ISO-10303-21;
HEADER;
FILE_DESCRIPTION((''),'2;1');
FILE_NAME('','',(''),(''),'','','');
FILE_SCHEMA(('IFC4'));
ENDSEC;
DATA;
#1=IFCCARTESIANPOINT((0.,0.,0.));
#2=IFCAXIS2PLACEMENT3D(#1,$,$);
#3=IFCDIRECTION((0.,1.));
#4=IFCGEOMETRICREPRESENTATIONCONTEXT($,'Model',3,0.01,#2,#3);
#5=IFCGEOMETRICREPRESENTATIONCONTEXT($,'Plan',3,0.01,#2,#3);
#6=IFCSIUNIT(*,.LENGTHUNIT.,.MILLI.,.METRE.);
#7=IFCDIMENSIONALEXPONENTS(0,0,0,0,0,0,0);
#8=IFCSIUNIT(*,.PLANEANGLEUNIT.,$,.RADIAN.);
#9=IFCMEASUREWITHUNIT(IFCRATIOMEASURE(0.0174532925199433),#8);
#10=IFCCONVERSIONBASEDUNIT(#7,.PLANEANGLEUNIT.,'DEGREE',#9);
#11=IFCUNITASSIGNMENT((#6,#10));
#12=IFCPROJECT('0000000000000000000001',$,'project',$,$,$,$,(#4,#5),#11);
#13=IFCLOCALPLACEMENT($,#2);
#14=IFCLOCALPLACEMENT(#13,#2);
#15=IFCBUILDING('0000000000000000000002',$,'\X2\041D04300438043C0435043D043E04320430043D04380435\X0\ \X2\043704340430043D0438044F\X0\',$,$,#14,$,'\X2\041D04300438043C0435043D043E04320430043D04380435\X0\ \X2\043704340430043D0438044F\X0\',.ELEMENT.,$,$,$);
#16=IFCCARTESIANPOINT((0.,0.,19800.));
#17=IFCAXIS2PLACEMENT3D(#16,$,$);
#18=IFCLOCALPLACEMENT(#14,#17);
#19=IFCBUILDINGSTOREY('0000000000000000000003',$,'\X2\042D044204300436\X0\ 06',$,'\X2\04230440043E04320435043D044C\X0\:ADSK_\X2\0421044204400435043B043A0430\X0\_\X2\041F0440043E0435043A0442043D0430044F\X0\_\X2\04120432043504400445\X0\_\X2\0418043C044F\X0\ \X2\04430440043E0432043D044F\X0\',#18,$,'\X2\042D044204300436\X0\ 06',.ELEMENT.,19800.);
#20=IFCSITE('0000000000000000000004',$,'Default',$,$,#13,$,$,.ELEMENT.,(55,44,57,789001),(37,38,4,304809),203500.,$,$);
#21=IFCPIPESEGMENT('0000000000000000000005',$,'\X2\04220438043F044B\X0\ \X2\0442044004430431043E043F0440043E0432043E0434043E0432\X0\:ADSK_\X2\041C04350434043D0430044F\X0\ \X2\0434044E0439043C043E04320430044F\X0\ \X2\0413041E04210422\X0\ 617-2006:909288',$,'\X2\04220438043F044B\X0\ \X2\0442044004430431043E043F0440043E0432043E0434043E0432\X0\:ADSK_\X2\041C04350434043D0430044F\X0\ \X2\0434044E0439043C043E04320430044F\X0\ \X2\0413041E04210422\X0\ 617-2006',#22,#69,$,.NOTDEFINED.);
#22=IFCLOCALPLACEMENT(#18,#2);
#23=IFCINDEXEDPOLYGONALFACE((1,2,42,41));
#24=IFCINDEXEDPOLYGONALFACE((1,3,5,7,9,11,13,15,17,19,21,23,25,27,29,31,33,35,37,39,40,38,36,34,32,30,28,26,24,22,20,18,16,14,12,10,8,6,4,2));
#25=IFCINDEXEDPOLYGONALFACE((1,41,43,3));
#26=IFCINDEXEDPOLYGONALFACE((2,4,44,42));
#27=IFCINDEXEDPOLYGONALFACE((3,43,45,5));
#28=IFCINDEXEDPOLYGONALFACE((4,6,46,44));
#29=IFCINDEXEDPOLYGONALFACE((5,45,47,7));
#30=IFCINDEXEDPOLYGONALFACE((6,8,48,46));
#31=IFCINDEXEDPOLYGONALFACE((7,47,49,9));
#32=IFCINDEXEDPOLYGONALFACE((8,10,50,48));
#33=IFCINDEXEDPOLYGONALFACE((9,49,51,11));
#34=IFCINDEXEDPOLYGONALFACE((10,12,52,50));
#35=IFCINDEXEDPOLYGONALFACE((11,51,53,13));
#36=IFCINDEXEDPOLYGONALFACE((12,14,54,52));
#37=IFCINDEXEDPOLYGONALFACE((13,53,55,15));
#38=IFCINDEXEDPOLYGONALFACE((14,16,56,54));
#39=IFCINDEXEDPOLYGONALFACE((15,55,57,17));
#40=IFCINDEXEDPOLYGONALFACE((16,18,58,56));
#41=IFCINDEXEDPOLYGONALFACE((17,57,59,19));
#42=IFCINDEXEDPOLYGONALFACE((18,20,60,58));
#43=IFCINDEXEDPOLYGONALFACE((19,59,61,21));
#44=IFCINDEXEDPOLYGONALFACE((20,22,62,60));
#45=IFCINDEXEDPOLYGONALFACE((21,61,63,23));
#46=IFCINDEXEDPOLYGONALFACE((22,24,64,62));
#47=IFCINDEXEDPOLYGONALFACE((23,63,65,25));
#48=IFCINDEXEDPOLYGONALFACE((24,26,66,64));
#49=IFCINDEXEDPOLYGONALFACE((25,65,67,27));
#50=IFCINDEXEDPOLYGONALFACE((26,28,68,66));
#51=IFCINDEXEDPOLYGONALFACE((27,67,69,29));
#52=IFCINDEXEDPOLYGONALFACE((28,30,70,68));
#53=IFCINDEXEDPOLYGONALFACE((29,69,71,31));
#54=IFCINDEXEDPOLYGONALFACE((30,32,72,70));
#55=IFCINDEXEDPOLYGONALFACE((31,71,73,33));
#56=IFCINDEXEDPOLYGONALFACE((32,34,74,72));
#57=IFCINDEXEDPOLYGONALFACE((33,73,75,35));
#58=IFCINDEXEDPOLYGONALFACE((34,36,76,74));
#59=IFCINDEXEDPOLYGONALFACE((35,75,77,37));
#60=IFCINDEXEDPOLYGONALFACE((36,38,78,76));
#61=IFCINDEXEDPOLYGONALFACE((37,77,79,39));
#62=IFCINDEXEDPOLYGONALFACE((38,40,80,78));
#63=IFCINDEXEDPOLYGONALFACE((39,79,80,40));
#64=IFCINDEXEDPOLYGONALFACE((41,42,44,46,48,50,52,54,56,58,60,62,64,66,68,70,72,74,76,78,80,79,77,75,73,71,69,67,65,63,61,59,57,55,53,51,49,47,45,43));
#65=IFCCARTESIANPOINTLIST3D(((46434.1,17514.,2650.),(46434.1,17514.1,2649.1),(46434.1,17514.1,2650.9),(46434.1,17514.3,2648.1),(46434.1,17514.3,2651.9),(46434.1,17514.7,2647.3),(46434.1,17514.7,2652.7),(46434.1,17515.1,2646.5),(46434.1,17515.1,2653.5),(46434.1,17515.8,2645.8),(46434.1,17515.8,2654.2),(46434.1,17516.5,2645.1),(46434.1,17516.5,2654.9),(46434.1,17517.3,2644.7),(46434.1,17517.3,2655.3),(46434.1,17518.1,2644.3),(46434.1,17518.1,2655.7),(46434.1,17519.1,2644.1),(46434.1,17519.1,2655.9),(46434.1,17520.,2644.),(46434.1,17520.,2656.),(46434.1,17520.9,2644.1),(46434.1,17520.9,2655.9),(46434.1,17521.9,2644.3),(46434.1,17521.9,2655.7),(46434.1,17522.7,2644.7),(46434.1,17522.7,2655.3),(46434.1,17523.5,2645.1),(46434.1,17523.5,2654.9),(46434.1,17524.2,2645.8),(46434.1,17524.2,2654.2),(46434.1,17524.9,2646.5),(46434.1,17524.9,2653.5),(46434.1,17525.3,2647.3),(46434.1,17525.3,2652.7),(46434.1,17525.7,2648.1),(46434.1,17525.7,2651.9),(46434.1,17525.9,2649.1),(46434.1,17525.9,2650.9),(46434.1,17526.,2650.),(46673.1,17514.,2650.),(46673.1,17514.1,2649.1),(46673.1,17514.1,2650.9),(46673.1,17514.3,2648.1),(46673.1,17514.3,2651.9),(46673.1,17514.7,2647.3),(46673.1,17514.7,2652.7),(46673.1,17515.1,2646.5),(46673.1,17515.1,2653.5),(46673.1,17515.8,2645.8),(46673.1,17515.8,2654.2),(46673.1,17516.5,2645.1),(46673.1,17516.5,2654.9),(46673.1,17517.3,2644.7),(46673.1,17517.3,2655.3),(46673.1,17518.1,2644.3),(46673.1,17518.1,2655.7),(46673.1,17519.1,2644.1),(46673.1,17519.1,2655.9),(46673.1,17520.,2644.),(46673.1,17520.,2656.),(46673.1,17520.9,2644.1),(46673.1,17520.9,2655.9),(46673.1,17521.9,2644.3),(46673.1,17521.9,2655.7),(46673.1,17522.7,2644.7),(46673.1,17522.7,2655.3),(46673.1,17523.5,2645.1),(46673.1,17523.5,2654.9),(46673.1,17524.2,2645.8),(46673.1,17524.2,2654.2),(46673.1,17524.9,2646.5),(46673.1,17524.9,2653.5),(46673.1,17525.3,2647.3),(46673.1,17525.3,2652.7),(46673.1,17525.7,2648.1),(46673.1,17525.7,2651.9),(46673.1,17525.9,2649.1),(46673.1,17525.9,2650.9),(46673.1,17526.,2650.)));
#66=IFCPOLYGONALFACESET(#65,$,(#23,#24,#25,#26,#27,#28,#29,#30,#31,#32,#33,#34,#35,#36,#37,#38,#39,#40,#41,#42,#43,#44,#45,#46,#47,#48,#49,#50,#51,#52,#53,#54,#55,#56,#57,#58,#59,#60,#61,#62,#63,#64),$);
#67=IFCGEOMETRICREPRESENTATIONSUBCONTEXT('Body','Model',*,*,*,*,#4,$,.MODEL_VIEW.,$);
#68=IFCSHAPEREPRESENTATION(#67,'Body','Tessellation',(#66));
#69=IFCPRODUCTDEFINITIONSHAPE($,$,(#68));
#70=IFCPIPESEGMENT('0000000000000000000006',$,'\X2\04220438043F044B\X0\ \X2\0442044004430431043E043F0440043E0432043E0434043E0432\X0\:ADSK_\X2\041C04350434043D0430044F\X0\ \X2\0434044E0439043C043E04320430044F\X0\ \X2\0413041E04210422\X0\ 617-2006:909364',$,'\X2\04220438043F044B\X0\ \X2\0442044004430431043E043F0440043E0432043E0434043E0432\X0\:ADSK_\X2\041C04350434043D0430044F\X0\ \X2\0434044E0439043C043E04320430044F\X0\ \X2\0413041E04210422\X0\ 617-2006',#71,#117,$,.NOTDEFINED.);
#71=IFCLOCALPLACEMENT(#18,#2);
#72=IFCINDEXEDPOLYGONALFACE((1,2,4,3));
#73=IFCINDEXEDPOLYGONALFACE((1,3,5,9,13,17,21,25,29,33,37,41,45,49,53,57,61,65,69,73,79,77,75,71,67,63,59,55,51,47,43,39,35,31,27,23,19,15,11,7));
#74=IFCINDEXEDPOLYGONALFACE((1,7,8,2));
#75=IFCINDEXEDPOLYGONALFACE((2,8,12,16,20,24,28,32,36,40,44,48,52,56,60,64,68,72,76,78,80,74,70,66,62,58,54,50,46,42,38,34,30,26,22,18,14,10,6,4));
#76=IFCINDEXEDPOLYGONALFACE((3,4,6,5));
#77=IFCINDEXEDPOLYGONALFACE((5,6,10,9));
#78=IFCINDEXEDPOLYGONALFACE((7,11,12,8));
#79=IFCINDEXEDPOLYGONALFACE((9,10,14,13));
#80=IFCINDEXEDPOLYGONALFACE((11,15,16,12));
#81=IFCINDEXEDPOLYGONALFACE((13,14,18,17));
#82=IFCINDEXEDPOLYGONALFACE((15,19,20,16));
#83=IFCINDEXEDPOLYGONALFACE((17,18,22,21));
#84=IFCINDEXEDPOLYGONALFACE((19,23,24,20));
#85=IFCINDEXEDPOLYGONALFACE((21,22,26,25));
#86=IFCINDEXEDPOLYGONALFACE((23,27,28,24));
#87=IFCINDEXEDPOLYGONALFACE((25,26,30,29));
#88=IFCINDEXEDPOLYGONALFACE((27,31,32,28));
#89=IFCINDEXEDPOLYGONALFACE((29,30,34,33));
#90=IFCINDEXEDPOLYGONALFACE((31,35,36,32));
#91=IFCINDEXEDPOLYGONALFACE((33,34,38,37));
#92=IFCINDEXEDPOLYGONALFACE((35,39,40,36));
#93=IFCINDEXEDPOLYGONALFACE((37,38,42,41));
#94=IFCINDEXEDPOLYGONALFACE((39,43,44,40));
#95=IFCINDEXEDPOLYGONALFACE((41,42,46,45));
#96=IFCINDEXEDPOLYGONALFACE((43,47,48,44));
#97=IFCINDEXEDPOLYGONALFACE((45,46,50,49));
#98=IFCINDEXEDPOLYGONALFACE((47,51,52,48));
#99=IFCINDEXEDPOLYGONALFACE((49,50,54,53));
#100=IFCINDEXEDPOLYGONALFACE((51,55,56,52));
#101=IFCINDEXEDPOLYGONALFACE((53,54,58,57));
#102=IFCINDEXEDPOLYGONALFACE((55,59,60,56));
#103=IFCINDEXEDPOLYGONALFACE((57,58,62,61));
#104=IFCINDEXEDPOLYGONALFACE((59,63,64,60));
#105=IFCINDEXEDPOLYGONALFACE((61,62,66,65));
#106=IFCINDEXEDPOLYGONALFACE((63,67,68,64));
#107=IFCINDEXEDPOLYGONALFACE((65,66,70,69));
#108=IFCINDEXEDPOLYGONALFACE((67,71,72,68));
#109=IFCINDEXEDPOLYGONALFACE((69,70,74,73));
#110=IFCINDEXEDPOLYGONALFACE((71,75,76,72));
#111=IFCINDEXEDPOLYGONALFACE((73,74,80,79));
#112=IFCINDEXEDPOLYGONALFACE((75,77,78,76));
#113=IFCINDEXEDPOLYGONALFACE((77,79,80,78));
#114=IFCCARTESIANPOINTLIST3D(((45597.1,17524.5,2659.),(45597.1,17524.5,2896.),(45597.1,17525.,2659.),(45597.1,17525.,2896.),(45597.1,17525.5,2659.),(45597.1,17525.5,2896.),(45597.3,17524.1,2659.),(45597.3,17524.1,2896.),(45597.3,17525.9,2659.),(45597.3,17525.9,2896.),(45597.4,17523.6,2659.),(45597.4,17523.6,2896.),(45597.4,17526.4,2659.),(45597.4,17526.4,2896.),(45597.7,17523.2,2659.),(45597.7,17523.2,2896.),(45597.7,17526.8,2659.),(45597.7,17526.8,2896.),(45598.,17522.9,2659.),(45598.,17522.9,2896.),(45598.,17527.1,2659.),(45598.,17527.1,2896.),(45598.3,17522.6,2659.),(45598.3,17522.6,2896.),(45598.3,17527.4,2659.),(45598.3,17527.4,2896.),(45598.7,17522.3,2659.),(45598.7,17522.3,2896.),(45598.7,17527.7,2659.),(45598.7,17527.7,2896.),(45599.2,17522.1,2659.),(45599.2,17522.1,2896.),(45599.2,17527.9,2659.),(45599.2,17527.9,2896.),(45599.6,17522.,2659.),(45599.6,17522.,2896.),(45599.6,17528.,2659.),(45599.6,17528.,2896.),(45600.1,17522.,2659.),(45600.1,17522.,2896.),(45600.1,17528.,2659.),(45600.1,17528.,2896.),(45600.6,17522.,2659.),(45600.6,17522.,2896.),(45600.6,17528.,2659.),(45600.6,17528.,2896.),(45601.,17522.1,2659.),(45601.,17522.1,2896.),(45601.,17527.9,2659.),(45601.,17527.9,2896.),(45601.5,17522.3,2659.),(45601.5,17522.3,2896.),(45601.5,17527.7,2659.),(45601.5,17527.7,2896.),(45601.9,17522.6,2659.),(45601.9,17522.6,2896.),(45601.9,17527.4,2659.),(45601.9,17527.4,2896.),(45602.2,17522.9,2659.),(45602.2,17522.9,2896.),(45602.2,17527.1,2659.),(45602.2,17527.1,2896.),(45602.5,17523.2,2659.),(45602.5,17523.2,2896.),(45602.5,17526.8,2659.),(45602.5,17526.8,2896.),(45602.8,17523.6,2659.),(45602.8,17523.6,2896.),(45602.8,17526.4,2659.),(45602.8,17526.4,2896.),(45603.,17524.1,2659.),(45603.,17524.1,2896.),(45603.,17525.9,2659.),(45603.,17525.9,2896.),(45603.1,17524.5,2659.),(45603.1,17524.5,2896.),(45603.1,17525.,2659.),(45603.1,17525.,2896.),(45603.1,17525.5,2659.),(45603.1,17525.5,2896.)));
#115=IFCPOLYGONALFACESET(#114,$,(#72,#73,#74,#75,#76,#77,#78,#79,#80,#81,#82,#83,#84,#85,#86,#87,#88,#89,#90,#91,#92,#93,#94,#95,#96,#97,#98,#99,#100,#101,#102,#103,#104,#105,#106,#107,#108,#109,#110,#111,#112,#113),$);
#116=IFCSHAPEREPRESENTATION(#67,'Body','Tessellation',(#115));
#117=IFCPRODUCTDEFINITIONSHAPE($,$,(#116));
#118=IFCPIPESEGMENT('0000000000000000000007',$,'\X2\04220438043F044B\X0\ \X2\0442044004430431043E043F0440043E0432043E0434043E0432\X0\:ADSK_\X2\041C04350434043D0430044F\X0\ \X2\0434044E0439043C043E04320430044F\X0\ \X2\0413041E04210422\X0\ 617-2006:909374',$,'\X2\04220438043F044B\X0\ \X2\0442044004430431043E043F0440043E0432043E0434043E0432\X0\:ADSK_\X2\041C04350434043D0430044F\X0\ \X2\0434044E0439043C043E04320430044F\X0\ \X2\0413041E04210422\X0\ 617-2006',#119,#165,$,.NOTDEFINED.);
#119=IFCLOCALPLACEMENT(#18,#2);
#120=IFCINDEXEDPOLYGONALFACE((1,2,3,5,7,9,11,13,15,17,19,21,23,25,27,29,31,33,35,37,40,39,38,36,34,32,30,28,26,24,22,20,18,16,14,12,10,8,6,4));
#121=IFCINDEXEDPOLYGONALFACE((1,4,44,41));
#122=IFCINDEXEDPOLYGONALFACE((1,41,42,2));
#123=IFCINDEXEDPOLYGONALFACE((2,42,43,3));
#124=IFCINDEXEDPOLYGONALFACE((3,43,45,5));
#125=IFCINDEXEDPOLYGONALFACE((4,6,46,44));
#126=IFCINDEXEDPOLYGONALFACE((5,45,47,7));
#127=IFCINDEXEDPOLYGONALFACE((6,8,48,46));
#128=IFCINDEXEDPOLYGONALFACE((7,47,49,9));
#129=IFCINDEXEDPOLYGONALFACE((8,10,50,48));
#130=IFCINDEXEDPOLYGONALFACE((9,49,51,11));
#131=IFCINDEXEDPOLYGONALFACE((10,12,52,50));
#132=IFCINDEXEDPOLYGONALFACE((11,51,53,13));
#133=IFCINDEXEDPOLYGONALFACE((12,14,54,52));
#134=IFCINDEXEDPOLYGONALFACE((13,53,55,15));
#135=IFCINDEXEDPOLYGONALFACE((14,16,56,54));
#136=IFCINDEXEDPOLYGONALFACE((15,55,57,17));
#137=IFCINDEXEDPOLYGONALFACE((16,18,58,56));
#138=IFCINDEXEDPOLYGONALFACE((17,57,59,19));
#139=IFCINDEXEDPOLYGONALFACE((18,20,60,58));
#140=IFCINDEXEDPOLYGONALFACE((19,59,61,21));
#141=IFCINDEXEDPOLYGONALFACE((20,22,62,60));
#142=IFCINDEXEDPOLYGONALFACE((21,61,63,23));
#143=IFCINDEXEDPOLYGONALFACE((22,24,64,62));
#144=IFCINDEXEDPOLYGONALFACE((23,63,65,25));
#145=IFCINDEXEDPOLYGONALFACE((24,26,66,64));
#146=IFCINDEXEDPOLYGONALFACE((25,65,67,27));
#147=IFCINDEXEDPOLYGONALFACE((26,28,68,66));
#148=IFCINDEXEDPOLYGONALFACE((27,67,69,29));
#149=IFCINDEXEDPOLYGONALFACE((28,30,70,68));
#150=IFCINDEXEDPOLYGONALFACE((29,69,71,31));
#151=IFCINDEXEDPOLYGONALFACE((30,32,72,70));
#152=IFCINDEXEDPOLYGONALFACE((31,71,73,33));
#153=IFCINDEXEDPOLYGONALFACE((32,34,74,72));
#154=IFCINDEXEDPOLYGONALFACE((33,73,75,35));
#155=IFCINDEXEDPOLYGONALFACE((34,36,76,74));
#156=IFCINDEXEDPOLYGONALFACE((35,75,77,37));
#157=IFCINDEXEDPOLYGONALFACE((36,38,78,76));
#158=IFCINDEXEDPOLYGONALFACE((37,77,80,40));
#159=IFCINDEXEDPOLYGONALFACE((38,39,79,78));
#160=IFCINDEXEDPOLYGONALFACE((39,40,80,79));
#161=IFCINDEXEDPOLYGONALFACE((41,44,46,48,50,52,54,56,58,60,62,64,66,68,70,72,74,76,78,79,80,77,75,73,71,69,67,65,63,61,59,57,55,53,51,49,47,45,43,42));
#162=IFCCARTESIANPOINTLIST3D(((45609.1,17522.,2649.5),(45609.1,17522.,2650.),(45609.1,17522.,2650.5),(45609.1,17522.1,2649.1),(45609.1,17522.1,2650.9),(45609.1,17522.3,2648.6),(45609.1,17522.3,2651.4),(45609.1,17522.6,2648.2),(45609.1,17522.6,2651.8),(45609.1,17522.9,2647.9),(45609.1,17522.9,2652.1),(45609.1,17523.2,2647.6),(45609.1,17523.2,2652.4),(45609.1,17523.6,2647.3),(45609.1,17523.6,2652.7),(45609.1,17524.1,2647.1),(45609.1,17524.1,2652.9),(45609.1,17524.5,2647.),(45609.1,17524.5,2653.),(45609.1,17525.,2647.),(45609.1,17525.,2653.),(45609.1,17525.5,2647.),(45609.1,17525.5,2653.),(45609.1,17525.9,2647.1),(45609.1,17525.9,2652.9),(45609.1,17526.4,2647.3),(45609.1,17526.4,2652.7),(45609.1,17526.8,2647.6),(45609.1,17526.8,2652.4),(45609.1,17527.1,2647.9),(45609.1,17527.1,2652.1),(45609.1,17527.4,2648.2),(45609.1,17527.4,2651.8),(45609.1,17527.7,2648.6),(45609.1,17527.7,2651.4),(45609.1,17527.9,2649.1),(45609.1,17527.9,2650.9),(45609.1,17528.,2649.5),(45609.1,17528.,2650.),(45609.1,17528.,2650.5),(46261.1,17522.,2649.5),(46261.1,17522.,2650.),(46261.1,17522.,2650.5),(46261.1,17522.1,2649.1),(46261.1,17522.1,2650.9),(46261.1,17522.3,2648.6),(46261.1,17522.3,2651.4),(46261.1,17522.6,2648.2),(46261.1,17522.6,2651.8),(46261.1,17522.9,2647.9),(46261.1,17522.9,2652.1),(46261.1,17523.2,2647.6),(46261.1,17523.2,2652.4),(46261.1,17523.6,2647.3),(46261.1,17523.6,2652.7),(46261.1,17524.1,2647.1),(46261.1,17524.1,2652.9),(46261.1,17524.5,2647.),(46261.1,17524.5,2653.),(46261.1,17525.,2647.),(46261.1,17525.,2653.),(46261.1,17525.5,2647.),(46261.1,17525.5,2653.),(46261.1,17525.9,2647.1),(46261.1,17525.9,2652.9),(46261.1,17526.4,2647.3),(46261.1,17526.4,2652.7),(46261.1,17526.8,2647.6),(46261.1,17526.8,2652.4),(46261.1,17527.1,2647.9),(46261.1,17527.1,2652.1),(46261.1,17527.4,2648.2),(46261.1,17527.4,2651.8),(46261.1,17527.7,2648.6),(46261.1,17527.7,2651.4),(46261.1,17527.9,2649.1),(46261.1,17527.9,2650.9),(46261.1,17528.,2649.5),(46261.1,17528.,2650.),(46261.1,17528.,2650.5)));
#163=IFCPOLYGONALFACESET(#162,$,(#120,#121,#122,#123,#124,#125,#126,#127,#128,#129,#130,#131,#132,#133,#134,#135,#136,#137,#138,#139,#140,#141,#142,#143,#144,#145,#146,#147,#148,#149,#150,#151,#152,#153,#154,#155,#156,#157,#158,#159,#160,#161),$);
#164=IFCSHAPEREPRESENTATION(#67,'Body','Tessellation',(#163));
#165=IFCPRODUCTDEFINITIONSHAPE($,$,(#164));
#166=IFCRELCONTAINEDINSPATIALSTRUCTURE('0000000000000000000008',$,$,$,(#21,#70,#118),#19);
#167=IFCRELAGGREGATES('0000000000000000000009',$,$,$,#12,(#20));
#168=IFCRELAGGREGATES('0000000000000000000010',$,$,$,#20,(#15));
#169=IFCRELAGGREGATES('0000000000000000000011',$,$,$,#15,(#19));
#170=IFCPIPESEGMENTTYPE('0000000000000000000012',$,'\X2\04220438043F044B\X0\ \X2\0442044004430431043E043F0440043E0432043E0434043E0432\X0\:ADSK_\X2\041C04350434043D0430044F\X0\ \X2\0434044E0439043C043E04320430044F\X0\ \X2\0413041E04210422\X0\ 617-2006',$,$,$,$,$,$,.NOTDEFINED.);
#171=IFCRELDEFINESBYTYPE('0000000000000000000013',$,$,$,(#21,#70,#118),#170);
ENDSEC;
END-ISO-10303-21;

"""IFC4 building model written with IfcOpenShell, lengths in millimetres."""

from ifc_helpers import new_model, entity, si_unit, converted_unit, direction, frame, origin, place, context, subcontext, project, spatial, indexed_curve, outline, extrude, type_object, element, save


model = new_model("IFC4")

# Units and contexts
model_context = context("Model", 3, precision=0.01, world=origin(), true_north=direction((0.0, 1.0)))
plan_context = context("Plan", 3, precision=0.01, world=origin(), true_north=direction((0.0, 1.0)))
body_context = subcontext(model_context, "Body", "Model", "MODEL_VIEW")
ifc_project = project(units=[si_unit("LENGTHUNIT", "METRE", prefix="MILLI"), converted_unit("PLANEANGLEUNIT", "DEGREE", entity("IfcRatioMeasure", 0.0174532925199433), si_unit("PLANEANGLEUNIT", "RADIAN"), dimensions=[0, 0, 0, 0, 0, 0, 0])], contexts=[model_context, plan_context])

# Site, building, storey
site_placement = place(None, origin())
site = spatial("IfcSite", under=ifc_project, at=site_placement, Name="Default", CompositionType="ELEMENT", RefLatitude=(55, 44, 57, 789001), RefLongitude=(37, 38, 4, 304809), RefElevation=203500.0)
building_placement = place(site_placement, origin())
building = spatial("IfcBuilding", under=site, at=building_placement, Name="Наименование здания", LongName="Наименование здания", CompositionType="ELEMENT")
storey_placement = place(building_placement, frame((0.0, 0.0, 19800.0)))
storey = spatial("IfcBuildingStorey", under=building, at=storey_placement, Name="Этаж 06", ObjectType="Уровень:ADSK_Стрелка_Проектная_Вверх_Имя уровня", LongName="Этаж 06", CompositionType="ELEMENT", Elevation=19800.0)

# Pipe segments
pipe_segment_type = type_object("IfcPipeSegmentType", Name="Типы трубопроводов:ADSK_Медная дюймовая ГОСТ 617-2006", PredefinedType="NOTDEFINED")
placement = place(storey_placement, origin())
element("IfcPipeSegment", 1, at=placement, inside=storey, type_object=pipe_segment_type, Name="Типы трубопроводов:ADSK_Медная дюймовая ГОСТ 617-2006:909288", ObjectType="Типы трубопроводов:ADSK_Медная дюймовая ГОСТ 617-2006", PredefinedType="NOTDEFINED", context=body_context, shape_type="SweptSolid", body=[
    extrude(outline(indexed_curve([(6.0, 0.0), (5.9, 0.9), (5.7, 1.9), (5.3, 2.7), (4.9, 3.5), (4.2, 4.2), (3.5, 4.9), (2.7, 5.3), (1.9, 5.7), (0.9, 5.9), (0.0, 6.0), (-0.9, 5.9), (-1.9, 5.7), (-2.7, 5.3), (-3.5, 4.9), (-4.2, 4.2), (-4.9, 3.5), (-5.3, 2.7), (-5.7, 1.9), (-5.9, 0.9), (-6.0, 0.0), (-5.9, -0.9), (-5.7, -1.9), (-5.3, -2.7), (-4.9, -3.5), (-4.2, -4.2), (-3.5, -4.9), (-2.7, -5.3), (-1.9, -5.7), (-0.9, -5.9), (0.0, -6.0), (0.9, -5.9), (1.9, -5.7), (2.7, -5.3), (3.5, -4.9), (4.2, -4.2), (4.9, -3.5), (5.3, -2.7), (5.7, -1.9), (5.9, -0.9), (6.0, 0.0)], self_intersect=False)), frame((46434.1, 17520.0, 2650.0), z_axis=(1.0, 0.0, 0.0), x_axis=(0.0, 1.0, 0.0)), (0.0, 0.0, 1.0), 239.0),
])
element("IfcPipeSegment", 2, at=placement, inside=storey, type_object=pipe_segment_type, Name="Типы трубопроводов:ADSK_Медная дюймовая ГОСТ 617-2006:909364", ObjectType="Типы трубопроводов:ADSK_Медная дюймовая ГОСТ 617-2006", PredefinedType="NOTDEFINED", context=body_context, shape_type="SweptSolid", body=[
    extrude(outline(indexed_curve([(3.0, 0.0), (3.0, 0.5), (2.9, 0.9), (2.7, 1.4), (2.4, 1.8), (2.1, 2.1), (1.8, 2.4), (1.4, 2.7), (0.9, 2.9), (0.5, 3.0), (0.0, 3.0), (-0.5, 3.0), (-0.9, 2.9), (-1.4, 2.7), (-1.8, 2.4), (-2.1, 2.1), (-2.4, 1.8), (-2.7, 1.4), (-2.9, 0.9), (-3.0, 0.5), (-3.0, 0.0), (-3.0, -0.5), (-2.9, -0.9), (-2.7, -1.4), (-2.4, -1.8), (-2.1, -2.1), (-1.8, -2.4), (-1.4, -2.7), (-0.9, -2.9), (-0.5, -3.0), (0.0, -3.0), (0.5, -3.0), (0.9, -2.9), (1.4, -2.7), (1.8, -2.4), (2.1, -2.1), (2.4, -1.8), (2.7, -1.4), (2.9, -0.9), (3.0, -0.5), (3.0, 0.0)], self_intersect=False)), frame((45600.1, 17525.0, 2659.0), z_axis=(0.0, 0.0, 1.0), x_axis=(-1.0, 0.0, 0.0)), (0.0, 0.0, 1.0), 237.0),
])
element("IfcPipeSegment", 3, at=placement, inside=storey, type_object=pipe_segment_type, Name="Типы трубопроводов:ADSK_Медная дюймовая ГОСТ 617-2006:909374", ObjectType="Типы трубопроводов:ADSK_Медная дюймовая ГОСТ 617-2006", PredefinedType="NOTDEFINED", context=body_context, shape_type="SweptSolid", body=[
    extrude(outline(indexed_curve([(3.0, 0.0), (3.0, 0.5), (2.9, 0.9), (2.7, 1.4), (2.4, 1.8), (2.1, 2.1), (1.8, 2.4), (1.4, 2.7), (0.9, 2.9), (0.5, 3.0), (0.0, 3.0), (-0.5, 3.0), (-0.9, 2.9), (-1.4, 2.7), (-1.8, 2.4), (-2.1, 2.1), (-2.4, 1.8), (-2.7, 1.4), (-2.9, 0.9), (-3.0, 0.5), (-3.0, 0.0), (-3.0, -0.5), (-2.9, -0.9), (-2.7, -1.4), (-2.4, -1.8), (-2.1, -2.1), (-1.8, -2.4), (-1.4, -2.7), (-0.9, -2.9), (-0.5, -3.0), (0.0, -3.0), (0.5, -3.0), (0.9, -2.9), (1.4, -2.7), (1.8, -2.4), (2.1, -2.1), (2.4, -1.8), (2.7, -1.4), (2.9, -0.9), (3.0, -0.5), (3.0, 0.0)], self_intersect=False)), frame((45609.1, 17525.0, 2650.0), z_axis=(1.0, 0.0, 0.0), x_axis=(0.0, -1.0, 0.0)), (0.0, 0.0, 1.0), 652.0),
])

save(model, "model.ifc")
